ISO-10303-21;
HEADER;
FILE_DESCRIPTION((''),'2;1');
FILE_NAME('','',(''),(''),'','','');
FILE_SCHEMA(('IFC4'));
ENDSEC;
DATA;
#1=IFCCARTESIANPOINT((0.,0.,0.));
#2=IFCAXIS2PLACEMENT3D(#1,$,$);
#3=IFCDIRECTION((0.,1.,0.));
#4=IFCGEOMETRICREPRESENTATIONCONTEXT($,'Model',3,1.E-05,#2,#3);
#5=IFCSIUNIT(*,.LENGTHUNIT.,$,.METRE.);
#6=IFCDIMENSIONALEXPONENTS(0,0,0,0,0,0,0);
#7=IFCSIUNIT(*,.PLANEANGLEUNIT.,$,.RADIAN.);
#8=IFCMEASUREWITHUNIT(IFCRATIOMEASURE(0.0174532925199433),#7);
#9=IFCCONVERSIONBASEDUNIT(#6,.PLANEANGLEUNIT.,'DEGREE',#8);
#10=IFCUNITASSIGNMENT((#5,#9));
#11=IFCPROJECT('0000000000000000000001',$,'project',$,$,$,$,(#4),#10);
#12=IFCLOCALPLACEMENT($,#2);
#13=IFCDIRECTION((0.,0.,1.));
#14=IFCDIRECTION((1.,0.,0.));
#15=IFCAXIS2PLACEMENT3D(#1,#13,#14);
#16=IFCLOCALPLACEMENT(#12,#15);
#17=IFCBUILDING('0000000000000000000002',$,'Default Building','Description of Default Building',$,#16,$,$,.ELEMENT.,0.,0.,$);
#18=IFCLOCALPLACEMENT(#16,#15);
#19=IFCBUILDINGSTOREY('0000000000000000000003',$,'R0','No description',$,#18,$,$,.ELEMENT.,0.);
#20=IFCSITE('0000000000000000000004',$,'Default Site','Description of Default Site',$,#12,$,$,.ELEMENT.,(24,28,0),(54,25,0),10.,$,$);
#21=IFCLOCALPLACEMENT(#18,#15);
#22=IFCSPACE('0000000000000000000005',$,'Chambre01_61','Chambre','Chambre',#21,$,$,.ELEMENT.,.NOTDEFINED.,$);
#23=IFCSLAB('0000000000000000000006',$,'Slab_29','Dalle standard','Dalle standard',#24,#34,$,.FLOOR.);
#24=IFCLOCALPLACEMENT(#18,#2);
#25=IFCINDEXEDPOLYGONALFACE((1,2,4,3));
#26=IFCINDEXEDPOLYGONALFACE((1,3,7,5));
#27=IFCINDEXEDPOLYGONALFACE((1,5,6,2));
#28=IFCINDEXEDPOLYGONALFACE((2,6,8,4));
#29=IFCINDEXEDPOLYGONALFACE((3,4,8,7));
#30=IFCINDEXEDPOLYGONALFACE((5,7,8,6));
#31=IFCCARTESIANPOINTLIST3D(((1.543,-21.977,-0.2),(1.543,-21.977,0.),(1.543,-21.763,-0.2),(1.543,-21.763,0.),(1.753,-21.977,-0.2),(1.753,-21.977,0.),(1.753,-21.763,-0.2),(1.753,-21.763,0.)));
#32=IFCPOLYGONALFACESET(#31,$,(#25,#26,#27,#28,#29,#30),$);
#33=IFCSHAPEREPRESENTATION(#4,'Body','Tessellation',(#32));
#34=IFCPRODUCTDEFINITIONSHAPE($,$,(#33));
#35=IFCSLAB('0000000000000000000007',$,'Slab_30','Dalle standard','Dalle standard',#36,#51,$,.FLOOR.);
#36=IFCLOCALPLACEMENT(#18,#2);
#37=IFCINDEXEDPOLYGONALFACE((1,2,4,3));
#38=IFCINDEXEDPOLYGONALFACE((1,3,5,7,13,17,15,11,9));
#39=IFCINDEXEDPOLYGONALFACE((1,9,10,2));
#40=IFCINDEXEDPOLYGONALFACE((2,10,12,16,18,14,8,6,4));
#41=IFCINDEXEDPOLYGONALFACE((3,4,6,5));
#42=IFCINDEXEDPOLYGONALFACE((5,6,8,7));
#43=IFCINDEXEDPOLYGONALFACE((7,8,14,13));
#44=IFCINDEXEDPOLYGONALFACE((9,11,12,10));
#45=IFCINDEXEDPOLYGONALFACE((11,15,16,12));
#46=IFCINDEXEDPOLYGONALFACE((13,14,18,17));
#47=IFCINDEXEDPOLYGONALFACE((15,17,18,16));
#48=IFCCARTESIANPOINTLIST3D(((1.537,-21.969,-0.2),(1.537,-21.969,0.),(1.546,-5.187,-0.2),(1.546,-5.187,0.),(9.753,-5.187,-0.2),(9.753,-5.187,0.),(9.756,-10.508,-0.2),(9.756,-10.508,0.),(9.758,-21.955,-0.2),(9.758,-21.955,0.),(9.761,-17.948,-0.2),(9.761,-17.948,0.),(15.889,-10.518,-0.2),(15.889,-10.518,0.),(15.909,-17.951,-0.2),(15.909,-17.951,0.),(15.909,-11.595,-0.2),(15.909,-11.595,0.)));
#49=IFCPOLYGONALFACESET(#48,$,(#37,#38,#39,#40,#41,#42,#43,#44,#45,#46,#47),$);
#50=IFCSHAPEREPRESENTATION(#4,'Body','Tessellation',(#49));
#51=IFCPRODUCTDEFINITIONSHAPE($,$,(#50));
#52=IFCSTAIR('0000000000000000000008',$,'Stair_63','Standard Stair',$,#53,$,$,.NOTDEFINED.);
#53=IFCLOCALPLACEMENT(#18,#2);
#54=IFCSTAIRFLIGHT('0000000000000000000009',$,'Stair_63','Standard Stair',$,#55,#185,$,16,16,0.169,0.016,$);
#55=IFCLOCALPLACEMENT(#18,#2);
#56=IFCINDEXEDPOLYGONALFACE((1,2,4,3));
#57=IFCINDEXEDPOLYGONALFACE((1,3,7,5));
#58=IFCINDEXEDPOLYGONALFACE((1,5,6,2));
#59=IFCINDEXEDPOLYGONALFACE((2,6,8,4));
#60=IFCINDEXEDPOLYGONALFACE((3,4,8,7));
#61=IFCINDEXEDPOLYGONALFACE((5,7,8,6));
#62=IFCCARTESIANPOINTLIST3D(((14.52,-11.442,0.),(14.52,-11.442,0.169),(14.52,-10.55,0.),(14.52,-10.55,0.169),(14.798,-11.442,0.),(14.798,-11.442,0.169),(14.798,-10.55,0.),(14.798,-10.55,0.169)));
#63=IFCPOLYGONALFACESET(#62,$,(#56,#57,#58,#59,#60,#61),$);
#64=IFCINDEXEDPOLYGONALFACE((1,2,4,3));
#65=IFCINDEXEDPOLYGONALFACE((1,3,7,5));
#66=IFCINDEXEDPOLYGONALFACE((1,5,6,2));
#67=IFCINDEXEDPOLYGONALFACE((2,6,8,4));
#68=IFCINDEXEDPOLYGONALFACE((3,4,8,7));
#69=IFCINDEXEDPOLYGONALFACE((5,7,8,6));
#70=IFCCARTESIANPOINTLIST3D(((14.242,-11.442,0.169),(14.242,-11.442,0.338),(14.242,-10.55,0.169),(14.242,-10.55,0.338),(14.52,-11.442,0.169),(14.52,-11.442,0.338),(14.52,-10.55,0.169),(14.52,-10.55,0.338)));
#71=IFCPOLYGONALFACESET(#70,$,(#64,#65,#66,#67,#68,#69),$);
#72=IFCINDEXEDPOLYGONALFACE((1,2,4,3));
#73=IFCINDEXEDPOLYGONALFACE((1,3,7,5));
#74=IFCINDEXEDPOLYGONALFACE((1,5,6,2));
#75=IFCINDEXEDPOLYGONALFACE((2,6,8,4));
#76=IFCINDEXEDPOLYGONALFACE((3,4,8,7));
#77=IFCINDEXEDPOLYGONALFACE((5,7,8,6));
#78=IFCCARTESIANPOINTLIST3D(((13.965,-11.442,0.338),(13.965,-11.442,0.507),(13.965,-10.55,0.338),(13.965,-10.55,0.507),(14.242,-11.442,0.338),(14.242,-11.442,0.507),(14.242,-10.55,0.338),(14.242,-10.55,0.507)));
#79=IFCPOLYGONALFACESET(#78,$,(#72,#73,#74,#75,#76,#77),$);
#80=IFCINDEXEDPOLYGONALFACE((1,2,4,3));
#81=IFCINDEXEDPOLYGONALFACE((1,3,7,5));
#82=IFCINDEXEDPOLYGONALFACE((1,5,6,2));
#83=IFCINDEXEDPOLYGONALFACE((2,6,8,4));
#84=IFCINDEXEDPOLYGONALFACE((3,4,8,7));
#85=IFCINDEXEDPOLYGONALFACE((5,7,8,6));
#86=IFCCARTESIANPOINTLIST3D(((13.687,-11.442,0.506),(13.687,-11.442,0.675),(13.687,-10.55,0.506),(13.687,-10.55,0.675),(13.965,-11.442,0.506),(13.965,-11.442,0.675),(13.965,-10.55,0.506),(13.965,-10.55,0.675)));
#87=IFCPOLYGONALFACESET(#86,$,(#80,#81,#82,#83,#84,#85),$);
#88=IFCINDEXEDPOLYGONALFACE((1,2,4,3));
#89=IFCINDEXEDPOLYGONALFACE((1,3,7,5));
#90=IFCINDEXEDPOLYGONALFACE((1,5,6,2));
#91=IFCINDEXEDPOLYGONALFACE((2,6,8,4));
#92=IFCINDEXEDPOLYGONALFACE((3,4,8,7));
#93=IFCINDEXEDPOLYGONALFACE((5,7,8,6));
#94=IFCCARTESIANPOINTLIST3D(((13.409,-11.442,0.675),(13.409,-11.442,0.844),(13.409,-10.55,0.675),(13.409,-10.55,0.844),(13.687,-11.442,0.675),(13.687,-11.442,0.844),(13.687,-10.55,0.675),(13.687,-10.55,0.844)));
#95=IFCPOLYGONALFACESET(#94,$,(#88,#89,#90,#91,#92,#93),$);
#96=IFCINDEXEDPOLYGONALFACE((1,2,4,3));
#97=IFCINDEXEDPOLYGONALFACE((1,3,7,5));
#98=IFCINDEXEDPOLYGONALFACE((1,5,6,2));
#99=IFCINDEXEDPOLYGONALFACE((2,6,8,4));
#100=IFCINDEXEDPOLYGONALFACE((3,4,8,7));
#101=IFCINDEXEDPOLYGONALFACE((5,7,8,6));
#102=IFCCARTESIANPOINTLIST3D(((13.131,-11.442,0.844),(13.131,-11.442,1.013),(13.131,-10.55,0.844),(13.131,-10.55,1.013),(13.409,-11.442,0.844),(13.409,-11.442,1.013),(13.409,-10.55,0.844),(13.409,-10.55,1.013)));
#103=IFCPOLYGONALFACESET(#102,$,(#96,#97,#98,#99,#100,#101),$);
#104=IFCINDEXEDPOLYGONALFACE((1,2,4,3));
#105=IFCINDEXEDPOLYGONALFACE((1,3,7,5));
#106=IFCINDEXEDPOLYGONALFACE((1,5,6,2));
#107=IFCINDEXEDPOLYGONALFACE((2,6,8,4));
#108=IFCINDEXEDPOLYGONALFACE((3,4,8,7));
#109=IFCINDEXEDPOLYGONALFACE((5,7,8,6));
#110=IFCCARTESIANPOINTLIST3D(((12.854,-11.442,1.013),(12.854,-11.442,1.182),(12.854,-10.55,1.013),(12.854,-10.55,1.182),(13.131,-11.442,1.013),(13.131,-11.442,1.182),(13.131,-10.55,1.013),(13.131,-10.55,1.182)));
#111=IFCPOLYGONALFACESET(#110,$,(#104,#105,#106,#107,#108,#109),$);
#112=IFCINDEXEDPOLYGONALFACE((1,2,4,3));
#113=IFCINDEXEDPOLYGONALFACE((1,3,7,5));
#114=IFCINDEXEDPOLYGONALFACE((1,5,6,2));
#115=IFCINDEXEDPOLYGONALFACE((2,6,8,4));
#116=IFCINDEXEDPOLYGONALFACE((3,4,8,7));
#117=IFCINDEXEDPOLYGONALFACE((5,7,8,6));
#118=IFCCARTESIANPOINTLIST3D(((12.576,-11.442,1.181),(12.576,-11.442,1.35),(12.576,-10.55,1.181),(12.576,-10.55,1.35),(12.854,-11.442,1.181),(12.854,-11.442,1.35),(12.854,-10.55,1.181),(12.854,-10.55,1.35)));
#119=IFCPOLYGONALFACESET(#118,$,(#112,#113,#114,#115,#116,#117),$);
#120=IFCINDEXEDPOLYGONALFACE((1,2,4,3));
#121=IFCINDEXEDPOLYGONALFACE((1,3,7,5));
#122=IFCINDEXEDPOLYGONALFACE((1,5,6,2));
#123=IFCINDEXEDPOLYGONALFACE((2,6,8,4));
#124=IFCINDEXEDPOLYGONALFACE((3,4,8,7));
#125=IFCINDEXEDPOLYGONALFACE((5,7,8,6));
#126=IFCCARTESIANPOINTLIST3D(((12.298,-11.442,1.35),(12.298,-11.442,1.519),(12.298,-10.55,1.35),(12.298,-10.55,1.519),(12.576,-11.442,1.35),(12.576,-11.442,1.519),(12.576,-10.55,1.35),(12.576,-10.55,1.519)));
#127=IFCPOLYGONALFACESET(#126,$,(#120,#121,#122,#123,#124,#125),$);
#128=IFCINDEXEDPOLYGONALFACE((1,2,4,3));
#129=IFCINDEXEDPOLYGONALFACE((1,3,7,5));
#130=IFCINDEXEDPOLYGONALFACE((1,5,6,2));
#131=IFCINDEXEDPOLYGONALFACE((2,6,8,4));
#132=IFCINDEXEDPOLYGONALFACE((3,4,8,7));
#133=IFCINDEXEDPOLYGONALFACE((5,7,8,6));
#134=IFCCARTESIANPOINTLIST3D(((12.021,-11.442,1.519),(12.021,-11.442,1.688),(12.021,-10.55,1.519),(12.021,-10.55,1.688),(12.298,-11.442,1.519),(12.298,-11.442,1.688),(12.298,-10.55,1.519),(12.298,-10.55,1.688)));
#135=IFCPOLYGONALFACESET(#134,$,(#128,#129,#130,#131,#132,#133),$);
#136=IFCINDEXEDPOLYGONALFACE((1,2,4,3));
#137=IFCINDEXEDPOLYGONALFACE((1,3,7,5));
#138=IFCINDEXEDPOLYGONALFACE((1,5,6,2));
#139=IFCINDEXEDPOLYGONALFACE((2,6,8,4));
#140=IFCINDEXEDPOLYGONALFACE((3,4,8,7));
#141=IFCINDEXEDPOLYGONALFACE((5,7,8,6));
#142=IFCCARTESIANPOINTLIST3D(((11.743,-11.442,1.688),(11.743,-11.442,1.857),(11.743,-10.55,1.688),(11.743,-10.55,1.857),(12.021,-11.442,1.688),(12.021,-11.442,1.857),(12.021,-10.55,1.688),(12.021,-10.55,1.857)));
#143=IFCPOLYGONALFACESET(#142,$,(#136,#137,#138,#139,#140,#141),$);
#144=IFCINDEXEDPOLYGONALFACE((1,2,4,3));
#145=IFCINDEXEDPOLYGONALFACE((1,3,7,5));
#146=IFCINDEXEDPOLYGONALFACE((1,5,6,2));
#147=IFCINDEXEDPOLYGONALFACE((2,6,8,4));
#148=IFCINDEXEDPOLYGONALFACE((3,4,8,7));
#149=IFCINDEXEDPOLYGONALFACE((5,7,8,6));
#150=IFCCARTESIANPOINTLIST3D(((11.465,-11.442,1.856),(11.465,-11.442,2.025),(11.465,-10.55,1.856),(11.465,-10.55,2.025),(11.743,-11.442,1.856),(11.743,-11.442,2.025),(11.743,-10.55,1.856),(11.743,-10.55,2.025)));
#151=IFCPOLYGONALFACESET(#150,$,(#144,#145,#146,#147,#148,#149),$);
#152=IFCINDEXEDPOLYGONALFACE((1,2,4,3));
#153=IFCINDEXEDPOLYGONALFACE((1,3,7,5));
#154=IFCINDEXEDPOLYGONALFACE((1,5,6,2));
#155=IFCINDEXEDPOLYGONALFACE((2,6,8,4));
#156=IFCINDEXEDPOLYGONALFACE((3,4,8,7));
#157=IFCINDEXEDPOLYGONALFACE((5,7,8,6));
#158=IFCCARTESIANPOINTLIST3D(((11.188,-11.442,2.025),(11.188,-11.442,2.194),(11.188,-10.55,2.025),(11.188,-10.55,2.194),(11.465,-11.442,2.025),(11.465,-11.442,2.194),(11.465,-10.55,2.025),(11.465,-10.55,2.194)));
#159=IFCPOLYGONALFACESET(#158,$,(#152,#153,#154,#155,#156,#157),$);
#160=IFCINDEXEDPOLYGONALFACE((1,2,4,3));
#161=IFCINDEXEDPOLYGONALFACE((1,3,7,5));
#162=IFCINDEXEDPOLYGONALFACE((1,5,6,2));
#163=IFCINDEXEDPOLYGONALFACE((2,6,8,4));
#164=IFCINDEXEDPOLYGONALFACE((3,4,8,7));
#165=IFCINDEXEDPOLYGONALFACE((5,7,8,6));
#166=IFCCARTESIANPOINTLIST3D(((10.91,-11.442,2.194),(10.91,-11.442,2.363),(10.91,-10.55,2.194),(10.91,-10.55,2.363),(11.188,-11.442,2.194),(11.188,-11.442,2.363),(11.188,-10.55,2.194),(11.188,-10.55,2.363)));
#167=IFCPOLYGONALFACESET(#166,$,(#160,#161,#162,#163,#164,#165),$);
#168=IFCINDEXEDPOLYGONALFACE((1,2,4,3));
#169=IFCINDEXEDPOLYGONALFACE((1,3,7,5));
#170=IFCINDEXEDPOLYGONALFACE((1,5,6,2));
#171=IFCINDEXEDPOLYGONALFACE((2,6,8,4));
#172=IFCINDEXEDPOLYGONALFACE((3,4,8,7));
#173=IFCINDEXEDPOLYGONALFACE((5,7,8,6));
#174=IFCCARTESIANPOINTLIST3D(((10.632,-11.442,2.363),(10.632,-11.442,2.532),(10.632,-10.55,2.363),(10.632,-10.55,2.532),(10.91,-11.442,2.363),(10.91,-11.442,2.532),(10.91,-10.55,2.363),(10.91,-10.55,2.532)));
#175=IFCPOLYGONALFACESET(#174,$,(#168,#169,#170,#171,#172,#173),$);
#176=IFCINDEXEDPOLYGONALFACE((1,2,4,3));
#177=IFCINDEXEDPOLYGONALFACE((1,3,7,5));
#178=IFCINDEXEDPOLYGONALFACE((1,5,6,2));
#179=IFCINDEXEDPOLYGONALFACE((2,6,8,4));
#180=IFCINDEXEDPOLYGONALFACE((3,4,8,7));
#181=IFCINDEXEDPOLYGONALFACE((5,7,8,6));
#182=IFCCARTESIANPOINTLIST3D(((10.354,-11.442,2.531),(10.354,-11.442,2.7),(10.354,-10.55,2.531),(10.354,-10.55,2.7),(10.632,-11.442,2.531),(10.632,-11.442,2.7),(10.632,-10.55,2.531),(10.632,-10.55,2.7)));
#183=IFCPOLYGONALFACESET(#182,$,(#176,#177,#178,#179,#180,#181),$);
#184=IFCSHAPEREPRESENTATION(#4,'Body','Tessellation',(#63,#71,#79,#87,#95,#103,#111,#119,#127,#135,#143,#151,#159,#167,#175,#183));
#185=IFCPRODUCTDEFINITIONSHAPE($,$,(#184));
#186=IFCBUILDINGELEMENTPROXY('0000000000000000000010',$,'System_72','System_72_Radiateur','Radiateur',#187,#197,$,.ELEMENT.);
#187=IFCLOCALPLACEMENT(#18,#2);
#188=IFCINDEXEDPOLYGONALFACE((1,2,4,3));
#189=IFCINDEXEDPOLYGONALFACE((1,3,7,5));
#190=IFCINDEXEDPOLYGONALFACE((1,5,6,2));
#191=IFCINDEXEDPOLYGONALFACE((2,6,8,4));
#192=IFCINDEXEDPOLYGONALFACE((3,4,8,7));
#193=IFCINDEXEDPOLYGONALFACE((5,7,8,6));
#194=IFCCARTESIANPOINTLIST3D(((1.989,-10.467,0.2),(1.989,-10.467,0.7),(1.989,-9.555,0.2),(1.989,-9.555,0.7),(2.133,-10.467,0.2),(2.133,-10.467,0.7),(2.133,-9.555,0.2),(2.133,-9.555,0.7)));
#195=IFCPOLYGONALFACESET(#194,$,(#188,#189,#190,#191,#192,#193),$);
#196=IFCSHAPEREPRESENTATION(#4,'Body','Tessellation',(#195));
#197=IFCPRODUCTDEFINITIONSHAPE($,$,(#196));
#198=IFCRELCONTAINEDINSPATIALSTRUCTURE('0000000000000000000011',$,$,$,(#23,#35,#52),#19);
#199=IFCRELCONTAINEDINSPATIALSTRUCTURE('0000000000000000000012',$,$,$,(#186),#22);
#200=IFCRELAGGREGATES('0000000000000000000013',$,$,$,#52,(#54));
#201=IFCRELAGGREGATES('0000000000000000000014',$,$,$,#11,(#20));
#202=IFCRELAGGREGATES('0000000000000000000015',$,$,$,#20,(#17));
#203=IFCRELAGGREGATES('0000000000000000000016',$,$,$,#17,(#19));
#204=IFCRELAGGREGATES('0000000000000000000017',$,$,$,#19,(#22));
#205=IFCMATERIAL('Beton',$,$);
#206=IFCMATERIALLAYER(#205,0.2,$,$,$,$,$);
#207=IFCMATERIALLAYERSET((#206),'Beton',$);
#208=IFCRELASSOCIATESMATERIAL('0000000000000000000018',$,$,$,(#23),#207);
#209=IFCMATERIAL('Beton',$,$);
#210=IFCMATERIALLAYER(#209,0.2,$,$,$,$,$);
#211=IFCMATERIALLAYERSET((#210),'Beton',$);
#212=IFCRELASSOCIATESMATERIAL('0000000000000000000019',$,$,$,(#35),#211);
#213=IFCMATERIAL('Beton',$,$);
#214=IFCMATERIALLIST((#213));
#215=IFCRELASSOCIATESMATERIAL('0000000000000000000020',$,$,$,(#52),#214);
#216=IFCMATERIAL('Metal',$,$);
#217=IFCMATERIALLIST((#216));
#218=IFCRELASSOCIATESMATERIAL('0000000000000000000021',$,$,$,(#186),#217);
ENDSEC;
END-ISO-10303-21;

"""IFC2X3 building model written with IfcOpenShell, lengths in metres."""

from ifc_helpers import new_model, entity, si_unit, converted_unit, direction, frame, origin, origin_with_axes, place, context, project, spatial, polyline, outline, extrude, material, material_list, layer, layer_set, layer_usage, element, aggregate, save


model = new_model("IFC2X3")

# Units and contexts
model_context = context("Model", 3, precision=1e-05, world=origin(), true_north=direction((0.0, 1.0, 0.0)))
ifc_project = project(units=[si_unit("LENGTHUNIT", "METRE"), converted_unit("PLANEANGLEUNIT", "DEGREE", entity("IfcRatioMeasure", 0.0174532925199433), si_unit("PLANEANGLEUNIT", "RADIAN"), dimensions=[0, 0, 0, 0, 0, 0, 0])], contexts=[model_context])

# Site, building, storey
site_placement = place(None, origin())
site = spatial("IfcSite", under=ifc_project, at=site_placement, Name="Default Site", Description="Description of Default Site", CompositionType="ELEMENT", RefLatitude=(24, 28, 0), RefLongitude=(54, 25, 0), RefElevation=10.0)
building_placement = place(site_placement, origin_with_axes())
building = spatial("IfcBuilding", under=site, at=building_placement, Name="Default Building", Description="Description of Default Building", CompositionType="ELEMENT", ElevationOfRefHeight=0.0, ElevationOfTerrain=0.0)
storey_placement = place(building_placement, origin_with_axes())
storey = spatial("IfcBuildingStorey", under=building, at=storey_placement, Name="R0", Description="No description", CompositionType="ELEMENT", Elevation=0.0)

# Slabs
ifc_material_1 = material(Name="Beton")
ifc_layer_1 = layer(ifc_material_1, 0.2)
ifc_layer_set_1 = layer_set([ifc_layer_1], Name="Beton")
ifc_layer_usage_1 = layer_usage(ifc_layer_set_1, "AXIS3", "POSITIVE", 0.2)
slab_1_placement = place(storey_placement, frame((0.0, 0.0, -0.2), z_axis=(0.0, 0.0, 1.0), x_axis=(1.0, 0.0, 0.0)))
element("IfcSlab", 1, at=slab_1_placement, inside=storey, material=ifc_layer_usage_1, Name="Slab_29", Description="Dalle standard", ObjectType="Dalle standard", PredefinedType="FLOOR", context=model_context, shape_type="SweptSolid", body=[
    extrude(outline(polyline([(1.543, -21.763), (1.543, -21.977), (1.753, -21.977), (1.753, -21.763), (1.543, -21.763)])), origin(), (0.0, 0.0, 1.0), 0.2),
])
ifc_material_2 = material(Name="Beton")
ifc_layer_2 = layer(ifc_material_2, 0.2)
ifc_layer_set_2 = layer_set([ifc_layer_2], Name="Beton")
ifc_layer_usage_2 = layer_usage(ifc_layer_set_2, "AXIS3", "POSITIVE", 0.2)
slab_2_placement = place(storey_placement, frame((0.0, 0.0, -0.2), z_axis=(0.0, 0.0, 1.0), x_axis=(1.0, 0.0, 0.0)))
element("IfcSlab", 2, at=slab_2_placement, inside=storey, material=ifc_layer_usage_2, Name="Slab_30", Description="Dalle standard", ObjectType="Dalle standard", PredefinedType="FLOOR", context=model_context, shape_type="SweptSolid", body=[
    extrude(outline(polyline([(9.753, -5.187), (9.756, -10.508), (15.889, -10.518), (15.909, -11.595), (15.909, -17.951), (9.761, -17.948), (9.758, -21.955), (1.537, -21.969), (1.546, -5.187), (9.753, -5.187)])), origin(), (0.0, 0.0, 1.0), 0.2),
])

# Shared definitions
space_1_placement = place(storey_placement, origin_with_axes())
space_1 = spatial("IfcSpace", under=storey, at=space_1_placement, Name="Chambre01_61", Description="Chambre", ObjectType="Chambre", CompositionType="ELEMENT", InteriorOrExteriorSpace="NOTDEFINED")

# Stair, stair flight
ifc_material_3 = material(Name="Beton")
ifc_material_list_1 = material_list([ifc_material_3])
placement = place(storey_placement, origin_with_axes())
stair = element("IfcStair", 3, at=placement, inside=storey, material=ifc_material_list_1, Name="Stair_63", Description="Standard Stair", ShapeType="NOTDEFINED")
stair_flight = element("IfcStairFlight", 4, at=placement, Name="Stair_63", Description="Standard Stair", NumberOfRiser=16, NumberOfTreads=16, RiserHeight=0.169, TreadLength=0.016, context=model_context, shape_type="SweptSolid", body=[
    extrude(outline(polyline([(14.798, -10.55, 0.0), (14.52, -10.55, 0.0), (14.52, -11.442, 0.0), (14.798, -11.442, 0.0), (14.798, -10.55, 0.0)])), origin(), (0.0, 0.0, 1.0), 0.169),
    extrude(outline(polyline([(14.52, -10.55, 0.169), (14.242, -10.55, 0.169), (14.242, -11.442, 0.169), (14.52, -11.442, 0.169), (14.52, -10.55, 0.169)])), origin(), (0.0, 0.0, 1.0), 0.169),
    extrude(outline(polyline([(14.242, -10.55, 0.338), (13.965, -10.55, 0.338), (13.965, -11.442, 0.338), (14.242, -11.442, 0.338), (14.242, -10.55, 0.338)])), origin(), (0.0, 0.0, 1.0), 0.169),
    extrude(outline(polyline([(13.965, -10.55, 0.506), (13.687, -10.55, 0.506), (13.687, -11.442, 0.506), (13.965, -11.442, 0.506), (13.965, -10.55, 0.506)])), origin(), (0.0, 0.0, 1.0), 0.169),
    extrude(outline(polyline([(13.687, -10.55, 0.675), (13.409, -10.55, 0.675), (13.409, -11.442, 0.675), (13.687, -11.442, 0.675), (13.687, -10.55, 0.675)])), origin(), (0.0, 0.0, 1.0), 0.169),
    extrude(outline(polyline([(13.409, -10.55, 0.844), (13.131, -10.55, 0.844), (13.131, -11.442, 0.844), (13.409, -11.442, 0.844), (13.409, -10.55, 0.844)])), origin(), (0.0, 0.0, 1.0), 0.169),
    extrude(outline(polyline([(13.131, -10.55, 1.013), (12.854, -10.55, 1.013), (12.854, -11.442, 1.013), (13.131, -11.442, 1.013), (13.131, -10.55, 1.013)])), origin(), (0.0, 0.0, 1.0), 0.169),
    extrude(outline(polyline([(12.854, -10.55, 1.181), (12.576, -10.55, 1.181), (12.576, -11.442, 1.181), (12.854, -11.442, 1.181), (12.854, -10.55, 1.181)])), origin(), (0.0, 0.0, 1.0), 0.169),
    extrude(outline(polyline([(12.576, -10.55, 1.35), (12.298, -10.55, 1.35), (12.298, -11.442, 1.35), (12.576, -11.442, 1.35), (12.576, -10.55, 1.35)])), origin(), (0.0, 0.0, 1.0), 0.169),
    extrude(outline(polyline([(12.298, -10.55, 1.519), (12.021, -10.55, 1.519), (12.021, -11.442, 1.519), (12.298, -11.442, 1.519), (12.298, -10.55, 1.519)])), origin(), (0.0, 0.0, 1.0), 0.169),
    extrude(outline(polyline([(12.021, -10.55, 1.688), (11.743, -10.55, 1.688), (11.743, -11.442, 1.688), (12.021, -11.442, 1.688), (12.021, -10.55, 1.688)])), origin(), (0.0, 0.0, 1.0), 0.169),
    extrude(outline(polyline([(11.743, -10.55, 1.856), (11.465, -10.55, 1.856), (11.465, -11.442, 1.856), (11.743, -11.442, 1.856), (11.743, -10.55, 1.856)])), origin(), (0.0, 0.0, 1.0), 0.169),
    extrude(outline(polyline([(11.465, -10.55, 2.025), (11.188, -10.55, 2.025), (11.188, -11.442, 2.025), (11.465, -11.442, 2.025), (11.465, -10.55, 2.025)])), origin(), (0.0, 0.0, 1.0), 0.169),
    extrude(outline(polyline([(11.188, -10.55, 2.194), (10.91, -10.55, 2.194), (10.91, -11.442, 2.194), (11.188, -11.442, 2.194), (11.188, -10.55, 2.194)])), origin(), (0.0, 0.0, 1.0), 0.169),
    extrude(outline(polyline([(10.91, -10.55, 2.363), (10.632, -10.55, 2.363), (10.632, -11.442, 2.363), (10.91, -11.442, 2.363), (10.91, -10.55, 2.363)])), origin(), (0.0, 0.0, 1.0), 0.169),
    extrude(outline(polyline([(10.632, -10.55, 2.531), (10.354, -10.55, 2.531), (10.354, -11.442, 2.531), (10.632, -11.442, 2.531), (10.632, -10.55, 2.531)])), origin(), (0.0, 0.0, 1.0), 0.169),
])
aggregate(stair, [stair_flight])

# Building element proxy
ifc_material_4 = material(Name="Metal")
ifc_material_list_2 = material_list([ifc_material_4])
proxy_placement = place(storey_placement, frame((2.061, -10.467, 0.2), z_axis=(0.0, 0.0, 1.0), x_axis=(0.0, 0.912, 0.0)))
element("IfcBuildingElementProxy", 5, at=proxy_placement, inside=space_1, material=ifc_material_list_2, Name="System_72", Description="System_72_Radiateur", ObjectType="Radiateur", CompositionType="ELEMENT", context=model_context, shape_type="SweptSolid", body=[
    extrude(outline(polyline([(0.0, -0.072), (0.912, -0.072), (0.912, 0.072), (0.0, 0.072), (0.0, -0.072)])), origin(), (0.0, 0.0, 1.0), 0.5),
])

save(model, "model.ifc")
